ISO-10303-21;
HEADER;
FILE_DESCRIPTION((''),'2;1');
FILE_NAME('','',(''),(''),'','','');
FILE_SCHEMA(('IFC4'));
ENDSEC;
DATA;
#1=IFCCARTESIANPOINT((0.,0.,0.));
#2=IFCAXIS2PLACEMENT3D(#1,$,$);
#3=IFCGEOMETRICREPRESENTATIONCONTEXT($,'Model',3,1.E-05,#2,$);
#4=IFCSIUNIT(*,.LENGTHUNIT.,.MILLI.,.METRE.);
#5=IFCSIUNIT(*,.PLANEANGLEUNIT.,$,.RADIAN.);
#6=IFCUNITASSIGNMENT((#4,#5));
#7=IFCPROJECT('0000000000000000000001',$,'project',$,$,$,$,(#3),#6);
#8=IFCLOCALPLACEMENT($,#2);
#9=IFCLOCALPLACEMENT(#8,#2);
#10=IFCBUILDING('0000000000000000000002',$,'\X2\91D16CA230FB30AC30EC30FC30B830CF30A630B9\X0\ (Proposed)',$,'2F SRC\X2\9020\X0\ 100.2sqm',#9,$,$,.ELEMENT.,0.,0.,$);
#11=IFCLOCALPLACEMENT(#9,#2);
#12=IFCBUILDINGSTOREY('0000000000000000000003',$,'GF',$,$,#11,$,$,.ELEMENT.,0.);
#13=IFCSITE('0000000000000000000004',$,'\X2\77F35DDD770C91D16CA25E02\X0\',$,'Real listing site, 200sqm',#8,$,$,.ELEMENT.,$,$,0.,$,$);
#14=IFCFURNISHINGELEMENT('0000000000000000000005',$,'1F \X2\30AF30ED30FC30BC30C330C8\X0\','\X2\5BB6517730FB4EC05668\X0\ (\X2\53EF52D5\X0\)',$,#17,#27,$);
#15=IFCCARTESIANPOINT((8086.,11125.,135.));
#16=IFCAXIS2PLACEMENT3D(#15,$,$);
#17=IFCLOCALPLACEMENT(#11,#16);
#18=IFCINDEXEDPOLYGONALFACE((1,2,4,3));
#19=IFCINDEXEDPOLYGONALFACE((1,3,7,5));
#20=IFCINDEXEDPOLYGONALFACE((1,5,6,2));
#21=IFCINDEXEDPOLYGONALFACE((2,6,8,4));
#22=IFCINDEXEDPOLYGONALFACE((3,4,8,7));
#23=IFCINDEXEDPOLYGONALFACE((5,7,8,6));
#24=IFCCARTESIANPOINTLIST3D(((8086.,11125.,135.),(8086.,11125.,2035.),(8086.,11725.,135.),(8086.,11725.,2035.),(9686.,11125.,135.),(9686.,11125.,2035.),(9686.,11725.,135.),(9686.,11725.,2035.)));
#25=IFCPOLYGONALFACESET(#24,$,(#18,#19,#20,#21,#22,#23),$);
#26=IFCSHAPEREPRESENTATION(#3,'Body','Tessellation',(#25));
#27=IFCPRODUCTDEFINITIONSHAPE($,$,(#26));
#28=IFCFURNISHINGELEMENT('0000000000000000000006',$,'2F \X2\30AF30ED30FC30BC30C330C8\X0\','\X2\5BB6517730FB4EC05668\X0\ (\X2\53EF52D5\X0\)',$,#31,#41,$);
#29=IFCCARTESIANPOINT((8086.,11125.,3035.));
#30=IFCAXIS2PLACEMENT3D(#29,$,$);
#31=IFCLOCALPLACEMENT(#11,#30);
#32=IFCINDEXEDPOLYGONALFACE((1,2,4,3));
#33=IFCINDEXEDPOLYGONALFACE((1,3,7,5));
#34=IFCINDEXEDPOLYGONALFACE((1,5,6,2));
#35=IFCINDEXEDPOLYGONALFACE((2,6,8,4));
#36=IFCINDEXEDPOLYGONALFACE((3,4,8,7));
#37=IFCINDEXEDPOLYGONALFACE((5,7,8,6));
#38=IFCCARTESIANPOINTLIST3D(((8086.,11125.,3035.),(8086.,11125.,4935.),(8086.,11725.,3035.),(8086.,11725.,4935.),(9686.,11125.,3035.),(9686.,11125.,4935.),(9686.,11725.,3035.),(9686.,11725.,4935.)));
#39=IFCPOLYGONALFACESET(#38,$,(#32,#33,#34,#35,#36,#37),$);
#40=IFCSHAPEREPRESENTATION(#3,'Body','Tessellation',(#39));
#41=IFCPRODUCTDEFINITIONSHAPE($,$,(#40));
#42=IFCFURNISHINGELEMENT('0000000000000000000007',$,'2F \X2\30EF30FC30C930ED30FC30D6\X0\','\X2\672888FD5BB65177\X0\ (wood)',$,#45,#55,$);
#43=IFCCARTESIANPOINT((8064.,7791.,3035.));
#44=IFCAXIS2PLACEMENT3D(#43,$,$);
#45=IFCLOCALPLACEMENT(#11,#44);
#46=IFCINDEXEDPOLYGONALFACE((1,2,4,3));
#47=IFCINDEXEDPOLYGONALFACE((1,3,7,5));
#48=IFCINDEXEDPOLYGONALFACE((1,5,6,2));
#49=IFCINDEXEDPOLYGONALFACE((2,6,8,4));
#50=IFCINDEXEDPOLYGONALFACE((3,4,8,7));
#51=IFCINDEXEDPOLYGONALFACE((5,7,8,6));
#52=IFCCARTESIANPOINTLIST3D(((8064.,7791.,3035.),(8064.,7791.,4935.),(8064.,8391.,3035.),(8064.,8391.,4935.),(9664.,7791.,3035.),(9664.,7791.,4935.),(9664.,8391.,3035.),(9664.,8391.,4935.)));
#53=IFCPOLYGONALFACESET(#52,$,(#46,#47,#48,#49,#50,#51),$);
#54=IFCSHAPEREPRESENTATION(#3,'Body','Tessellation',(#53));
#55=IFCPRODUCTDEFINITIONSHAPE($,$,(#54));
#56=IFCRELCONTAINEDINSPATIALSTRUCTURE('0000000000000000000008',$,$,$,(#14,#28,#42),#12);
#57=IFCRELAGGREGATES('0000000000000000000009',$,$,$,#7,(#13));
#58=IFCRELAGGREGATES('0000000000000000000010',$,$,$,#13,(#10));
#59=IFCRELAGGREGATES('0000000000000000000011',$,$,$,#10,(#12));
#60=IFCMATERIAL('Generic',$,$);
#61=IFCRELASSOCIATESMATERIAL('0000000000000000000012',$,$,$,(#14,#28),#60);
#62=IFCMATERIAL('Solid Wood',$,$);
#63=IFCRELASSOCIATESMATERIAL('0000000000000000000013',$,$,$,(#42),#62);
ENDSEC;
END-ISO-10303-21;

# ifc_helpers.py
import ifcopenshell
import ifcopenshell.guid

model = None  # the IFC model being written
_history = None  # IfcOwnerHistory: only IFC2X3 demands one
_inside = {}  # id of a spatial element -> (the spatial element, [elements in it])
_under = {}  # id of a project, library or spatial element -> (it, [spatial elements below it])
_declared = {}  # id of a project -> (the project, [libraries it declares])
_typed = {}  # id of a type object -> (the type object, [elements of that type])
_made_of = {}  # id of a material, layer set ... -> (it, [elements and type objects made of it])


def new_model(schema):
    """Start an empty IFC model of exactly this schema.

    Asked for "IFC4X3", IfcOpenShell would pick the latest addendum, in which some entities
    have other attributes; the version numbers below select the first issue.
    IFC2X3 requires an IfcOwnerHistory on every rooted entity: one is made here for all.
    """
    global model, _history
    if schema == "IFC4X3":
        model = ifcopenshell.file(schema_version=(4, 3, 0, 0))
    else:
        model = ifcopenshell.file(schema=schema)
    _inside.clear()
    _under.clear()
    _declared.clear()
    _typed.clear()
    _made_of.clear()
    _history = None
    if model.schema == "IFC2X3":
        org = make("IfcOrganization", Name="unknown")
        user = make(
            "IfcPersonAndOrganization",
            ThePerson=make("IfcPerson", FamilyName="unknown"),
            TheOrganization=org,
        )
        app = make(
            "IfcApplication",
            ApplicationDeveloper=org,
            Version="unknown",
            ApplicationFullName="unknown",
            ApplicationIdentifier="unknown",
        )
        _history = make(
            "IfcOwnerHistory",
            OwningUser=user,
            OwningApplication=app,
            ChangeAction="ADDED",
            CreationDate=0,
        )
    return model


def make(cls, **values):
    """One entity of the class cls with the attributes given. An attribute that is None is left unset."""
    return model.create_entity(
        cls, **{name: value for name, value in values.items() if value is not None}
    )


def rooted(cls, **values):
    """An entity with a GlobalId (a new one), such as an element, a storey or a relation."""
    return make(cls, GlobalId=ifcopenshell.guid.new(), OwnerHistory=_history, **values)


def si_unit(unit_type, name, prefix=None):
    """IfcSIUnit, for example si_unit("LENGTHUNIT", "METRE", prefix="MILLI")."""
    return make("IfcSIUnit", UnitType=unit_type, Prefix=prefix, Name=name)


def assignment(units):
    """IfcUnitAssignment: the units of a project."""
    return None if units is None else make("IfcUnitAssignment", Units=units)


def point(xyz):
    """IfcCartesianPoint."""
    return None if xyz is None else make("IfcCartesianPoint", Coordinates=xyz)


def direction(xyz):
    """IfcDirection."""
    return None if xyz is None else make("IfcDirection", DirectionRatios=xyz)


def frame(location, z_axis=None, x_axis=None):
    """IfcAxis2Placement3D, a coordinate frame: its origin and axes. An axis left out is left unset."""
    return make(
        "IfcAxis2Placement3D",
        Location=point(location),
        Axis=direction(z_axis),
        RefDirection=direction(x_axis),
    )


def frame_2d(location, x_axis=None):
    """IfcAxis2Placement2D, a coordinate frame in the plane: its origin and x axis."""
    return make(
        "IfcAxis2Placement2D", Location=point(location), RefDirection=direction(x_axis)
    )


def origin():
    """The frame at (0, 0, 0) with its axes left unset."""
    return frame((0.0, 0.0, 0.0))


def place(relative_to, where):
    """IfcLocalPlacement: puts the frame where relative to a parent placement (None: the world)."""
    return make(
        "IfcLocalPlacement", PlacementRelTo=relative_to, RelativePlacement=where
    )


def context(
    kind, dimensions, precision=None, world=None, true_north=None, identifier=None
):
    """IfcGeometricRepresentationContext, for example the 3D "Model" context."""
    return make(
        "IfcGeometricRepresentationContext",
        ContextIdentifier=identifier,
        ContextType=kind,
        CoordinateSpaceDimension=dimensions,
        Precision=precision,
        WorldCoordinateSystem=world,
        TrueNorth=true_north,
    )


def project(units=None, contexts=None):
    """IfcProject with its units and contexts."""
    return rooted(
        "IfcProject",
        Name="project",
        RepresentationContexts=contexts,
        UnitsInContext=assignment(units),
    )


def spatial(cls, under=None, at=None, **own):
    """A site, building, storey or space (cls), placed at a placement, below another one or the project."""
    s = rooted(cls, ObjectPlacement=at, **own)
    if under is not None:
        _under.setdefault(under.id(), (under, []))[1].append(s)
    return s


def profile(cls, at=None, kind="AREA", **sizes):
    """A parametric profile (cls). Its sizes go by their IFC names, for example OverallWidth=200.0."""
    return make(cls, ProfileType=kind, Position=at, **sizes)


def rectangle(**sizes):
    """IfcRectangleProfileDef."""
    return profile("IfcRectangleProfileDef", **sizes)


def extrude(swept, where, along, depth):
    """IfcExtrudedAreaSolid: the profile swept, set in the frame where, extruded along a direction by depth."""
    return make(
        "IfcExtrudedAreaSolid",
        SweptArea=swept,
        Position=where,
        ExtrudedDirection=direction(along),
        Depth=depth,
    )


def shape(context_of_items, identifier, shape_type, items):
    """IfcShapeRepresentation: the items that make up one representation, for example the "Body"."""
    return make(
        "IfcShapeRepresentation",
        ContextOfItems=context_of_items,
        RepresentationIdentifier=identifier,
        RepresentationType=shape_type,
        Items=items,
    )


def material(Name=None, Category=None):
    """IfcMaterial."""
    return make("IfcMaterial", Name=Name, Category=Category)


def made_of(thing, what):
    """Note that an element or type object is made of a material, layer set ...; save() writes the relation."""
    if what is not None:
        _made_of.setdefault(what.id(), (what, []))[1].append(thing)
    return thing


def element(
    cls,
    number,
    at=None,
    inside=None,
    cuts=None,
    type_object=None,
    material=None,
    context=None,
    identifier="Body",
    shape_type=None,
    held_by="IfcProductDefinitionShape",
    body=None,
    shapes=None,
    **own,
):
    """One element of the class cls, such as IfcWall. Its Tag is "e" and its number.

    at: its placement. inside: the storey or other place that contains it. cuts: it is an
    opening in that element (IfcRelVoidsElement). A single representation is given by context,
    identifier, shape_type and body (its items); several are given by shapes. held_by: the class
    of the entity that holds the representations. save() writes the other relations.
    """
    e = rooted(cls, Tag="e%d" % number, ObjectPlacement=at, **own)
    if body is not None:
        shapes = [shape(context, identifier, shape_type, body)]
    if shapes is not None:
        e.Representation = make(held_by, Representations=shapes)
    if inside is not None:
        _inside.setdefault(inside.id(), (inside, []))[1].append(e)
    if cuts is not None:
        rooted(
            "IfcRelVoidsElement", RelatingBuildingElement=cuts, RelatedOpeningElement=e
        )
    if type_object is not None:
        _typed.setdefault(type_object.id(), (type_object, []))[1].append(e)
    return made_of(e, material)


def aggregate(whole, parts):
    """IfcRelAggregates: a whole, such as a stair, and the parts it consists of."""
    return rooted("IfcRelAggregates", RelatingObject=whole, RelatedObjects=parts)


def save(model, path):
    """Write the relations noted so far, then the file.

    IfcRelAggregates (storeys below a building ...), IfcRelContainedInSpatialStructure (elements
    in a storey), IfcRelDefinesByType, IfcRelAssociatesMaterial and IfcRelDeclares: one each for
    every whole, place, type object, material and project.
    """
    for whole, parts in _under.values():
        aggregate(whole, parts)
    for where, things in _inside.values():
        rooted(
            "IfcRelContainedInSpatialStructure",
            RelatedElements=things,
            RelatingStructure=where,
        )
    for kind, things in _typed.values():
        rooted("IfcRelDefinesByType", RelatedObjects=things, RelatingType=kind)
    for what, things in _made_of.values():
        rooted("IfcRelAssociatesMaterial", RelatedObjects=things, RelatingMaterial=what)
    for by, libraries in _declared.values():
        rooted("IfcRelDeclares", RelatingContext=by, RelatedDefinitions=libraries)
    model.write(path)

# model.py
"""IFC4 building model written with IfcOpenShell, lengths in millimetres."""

from ifc_helpers import new_model, si_unit, frame, frame_2d, origin, place, context, project, spatial, rectangle, extrude, material, element, save


model = new_model("IFC4")

# Units and contexts
model_context = context("Model", 3, precision=1e-05, world=origin())
ifc_project = project(units=[si_unit("LENGTHUNIT", "METRE", prefix="MILLI"), si_unit("PLANEANGLEUNIT", "RADIAN")], contexts=[model_context])

# Site, building, storey
site_placement = place(None, origin())
site = spatial("IfcSite", under=ifc_project, at=site_placement, Name="石川県金沢市", ObjectType="Real listing site, 200sqm", CompositionType="ELEMENT", RefElevation=0.0)
building_placement = place(site_placement, origin())
building = spatial("IfcBuilding", under=site, at=building_placement, Name="金沢・ガレージハウス (Proposed)", ObjectType="2F SRC造 100.2sqm", CompositionType="ELEMENT", ElevationOfRefHeight=0.0, ElevationOfTerrain=0.0)
storey_placement = place(building_placement, origin())
storey = spatial("IfcBuildingStorey", under=building, at=storey_placement, Name="GF", CompositionType="ELEMENT", Elevation=0.0)

# Shared definitions
ifc_material_1 = material(Name="Solid Wood")

# Shared definitions
ifc_material_2 = material(Name="Generic")

# Furnishing elements
furnishing_1_placement = place(storey_placement, frame((8086.0, 11125.0, 135.0)))
element("IfcFurnishingElement", 1, at=furnishing_1_placement, inside=storey, material=ifc_material_2, Name="1F クローゼット", Description="家具・什器 (可動)", context=model_context, shape_type="SweptSolid", body=[
    extrude(rectangle(XDim=1600.0, YDim=600.0, at=frame_2d((800.0, 300.0))), frame((8086.0, 11125.0, 135.0)), (0.0, 0.0, 1.0), 1900.0),
])
furnishing_2_placement = place(storey_placement, frame((8086.0, 11125.0, 3035.0)))
element("IfcFurnishingElement", 2, at=furnishing_2_placement, inside=storey, material=ifc_material_2, Name="2F クローゼット", Description="家具・什器 (可動)", context=model_context, shape_type="SweptSolid", body=[
    extrude(rectangle(XDim=1600.0, YDim=600.0, at=frame_2d((800.0, 300.0))), frame((8086.0, 11125.0, 3035.0)), (0.0, 0.0, 1.0), 1900.0),
])
furnishing_3_placement = place(storey_placement, frame((8064.0, 7791.0, 3035.0)))
element("IfcFurnishingElement", 3, at=furnishing_3_placement, inside=storey, material=ifc_material_1, Name="2F ワードローブ", Description="木製家具 (wood)", context=model_context, shape_type="SweptSolid", body=[
    extrude(rectangle(XDim=1600.0, YDim=600.0, at=frame_2d((800.0, 300.0))), frame((8064.0, 7791.0, 3035.0)), (0.0, 0.0, 1.0), 1900.0),
])

save(model, "model.ifc")
